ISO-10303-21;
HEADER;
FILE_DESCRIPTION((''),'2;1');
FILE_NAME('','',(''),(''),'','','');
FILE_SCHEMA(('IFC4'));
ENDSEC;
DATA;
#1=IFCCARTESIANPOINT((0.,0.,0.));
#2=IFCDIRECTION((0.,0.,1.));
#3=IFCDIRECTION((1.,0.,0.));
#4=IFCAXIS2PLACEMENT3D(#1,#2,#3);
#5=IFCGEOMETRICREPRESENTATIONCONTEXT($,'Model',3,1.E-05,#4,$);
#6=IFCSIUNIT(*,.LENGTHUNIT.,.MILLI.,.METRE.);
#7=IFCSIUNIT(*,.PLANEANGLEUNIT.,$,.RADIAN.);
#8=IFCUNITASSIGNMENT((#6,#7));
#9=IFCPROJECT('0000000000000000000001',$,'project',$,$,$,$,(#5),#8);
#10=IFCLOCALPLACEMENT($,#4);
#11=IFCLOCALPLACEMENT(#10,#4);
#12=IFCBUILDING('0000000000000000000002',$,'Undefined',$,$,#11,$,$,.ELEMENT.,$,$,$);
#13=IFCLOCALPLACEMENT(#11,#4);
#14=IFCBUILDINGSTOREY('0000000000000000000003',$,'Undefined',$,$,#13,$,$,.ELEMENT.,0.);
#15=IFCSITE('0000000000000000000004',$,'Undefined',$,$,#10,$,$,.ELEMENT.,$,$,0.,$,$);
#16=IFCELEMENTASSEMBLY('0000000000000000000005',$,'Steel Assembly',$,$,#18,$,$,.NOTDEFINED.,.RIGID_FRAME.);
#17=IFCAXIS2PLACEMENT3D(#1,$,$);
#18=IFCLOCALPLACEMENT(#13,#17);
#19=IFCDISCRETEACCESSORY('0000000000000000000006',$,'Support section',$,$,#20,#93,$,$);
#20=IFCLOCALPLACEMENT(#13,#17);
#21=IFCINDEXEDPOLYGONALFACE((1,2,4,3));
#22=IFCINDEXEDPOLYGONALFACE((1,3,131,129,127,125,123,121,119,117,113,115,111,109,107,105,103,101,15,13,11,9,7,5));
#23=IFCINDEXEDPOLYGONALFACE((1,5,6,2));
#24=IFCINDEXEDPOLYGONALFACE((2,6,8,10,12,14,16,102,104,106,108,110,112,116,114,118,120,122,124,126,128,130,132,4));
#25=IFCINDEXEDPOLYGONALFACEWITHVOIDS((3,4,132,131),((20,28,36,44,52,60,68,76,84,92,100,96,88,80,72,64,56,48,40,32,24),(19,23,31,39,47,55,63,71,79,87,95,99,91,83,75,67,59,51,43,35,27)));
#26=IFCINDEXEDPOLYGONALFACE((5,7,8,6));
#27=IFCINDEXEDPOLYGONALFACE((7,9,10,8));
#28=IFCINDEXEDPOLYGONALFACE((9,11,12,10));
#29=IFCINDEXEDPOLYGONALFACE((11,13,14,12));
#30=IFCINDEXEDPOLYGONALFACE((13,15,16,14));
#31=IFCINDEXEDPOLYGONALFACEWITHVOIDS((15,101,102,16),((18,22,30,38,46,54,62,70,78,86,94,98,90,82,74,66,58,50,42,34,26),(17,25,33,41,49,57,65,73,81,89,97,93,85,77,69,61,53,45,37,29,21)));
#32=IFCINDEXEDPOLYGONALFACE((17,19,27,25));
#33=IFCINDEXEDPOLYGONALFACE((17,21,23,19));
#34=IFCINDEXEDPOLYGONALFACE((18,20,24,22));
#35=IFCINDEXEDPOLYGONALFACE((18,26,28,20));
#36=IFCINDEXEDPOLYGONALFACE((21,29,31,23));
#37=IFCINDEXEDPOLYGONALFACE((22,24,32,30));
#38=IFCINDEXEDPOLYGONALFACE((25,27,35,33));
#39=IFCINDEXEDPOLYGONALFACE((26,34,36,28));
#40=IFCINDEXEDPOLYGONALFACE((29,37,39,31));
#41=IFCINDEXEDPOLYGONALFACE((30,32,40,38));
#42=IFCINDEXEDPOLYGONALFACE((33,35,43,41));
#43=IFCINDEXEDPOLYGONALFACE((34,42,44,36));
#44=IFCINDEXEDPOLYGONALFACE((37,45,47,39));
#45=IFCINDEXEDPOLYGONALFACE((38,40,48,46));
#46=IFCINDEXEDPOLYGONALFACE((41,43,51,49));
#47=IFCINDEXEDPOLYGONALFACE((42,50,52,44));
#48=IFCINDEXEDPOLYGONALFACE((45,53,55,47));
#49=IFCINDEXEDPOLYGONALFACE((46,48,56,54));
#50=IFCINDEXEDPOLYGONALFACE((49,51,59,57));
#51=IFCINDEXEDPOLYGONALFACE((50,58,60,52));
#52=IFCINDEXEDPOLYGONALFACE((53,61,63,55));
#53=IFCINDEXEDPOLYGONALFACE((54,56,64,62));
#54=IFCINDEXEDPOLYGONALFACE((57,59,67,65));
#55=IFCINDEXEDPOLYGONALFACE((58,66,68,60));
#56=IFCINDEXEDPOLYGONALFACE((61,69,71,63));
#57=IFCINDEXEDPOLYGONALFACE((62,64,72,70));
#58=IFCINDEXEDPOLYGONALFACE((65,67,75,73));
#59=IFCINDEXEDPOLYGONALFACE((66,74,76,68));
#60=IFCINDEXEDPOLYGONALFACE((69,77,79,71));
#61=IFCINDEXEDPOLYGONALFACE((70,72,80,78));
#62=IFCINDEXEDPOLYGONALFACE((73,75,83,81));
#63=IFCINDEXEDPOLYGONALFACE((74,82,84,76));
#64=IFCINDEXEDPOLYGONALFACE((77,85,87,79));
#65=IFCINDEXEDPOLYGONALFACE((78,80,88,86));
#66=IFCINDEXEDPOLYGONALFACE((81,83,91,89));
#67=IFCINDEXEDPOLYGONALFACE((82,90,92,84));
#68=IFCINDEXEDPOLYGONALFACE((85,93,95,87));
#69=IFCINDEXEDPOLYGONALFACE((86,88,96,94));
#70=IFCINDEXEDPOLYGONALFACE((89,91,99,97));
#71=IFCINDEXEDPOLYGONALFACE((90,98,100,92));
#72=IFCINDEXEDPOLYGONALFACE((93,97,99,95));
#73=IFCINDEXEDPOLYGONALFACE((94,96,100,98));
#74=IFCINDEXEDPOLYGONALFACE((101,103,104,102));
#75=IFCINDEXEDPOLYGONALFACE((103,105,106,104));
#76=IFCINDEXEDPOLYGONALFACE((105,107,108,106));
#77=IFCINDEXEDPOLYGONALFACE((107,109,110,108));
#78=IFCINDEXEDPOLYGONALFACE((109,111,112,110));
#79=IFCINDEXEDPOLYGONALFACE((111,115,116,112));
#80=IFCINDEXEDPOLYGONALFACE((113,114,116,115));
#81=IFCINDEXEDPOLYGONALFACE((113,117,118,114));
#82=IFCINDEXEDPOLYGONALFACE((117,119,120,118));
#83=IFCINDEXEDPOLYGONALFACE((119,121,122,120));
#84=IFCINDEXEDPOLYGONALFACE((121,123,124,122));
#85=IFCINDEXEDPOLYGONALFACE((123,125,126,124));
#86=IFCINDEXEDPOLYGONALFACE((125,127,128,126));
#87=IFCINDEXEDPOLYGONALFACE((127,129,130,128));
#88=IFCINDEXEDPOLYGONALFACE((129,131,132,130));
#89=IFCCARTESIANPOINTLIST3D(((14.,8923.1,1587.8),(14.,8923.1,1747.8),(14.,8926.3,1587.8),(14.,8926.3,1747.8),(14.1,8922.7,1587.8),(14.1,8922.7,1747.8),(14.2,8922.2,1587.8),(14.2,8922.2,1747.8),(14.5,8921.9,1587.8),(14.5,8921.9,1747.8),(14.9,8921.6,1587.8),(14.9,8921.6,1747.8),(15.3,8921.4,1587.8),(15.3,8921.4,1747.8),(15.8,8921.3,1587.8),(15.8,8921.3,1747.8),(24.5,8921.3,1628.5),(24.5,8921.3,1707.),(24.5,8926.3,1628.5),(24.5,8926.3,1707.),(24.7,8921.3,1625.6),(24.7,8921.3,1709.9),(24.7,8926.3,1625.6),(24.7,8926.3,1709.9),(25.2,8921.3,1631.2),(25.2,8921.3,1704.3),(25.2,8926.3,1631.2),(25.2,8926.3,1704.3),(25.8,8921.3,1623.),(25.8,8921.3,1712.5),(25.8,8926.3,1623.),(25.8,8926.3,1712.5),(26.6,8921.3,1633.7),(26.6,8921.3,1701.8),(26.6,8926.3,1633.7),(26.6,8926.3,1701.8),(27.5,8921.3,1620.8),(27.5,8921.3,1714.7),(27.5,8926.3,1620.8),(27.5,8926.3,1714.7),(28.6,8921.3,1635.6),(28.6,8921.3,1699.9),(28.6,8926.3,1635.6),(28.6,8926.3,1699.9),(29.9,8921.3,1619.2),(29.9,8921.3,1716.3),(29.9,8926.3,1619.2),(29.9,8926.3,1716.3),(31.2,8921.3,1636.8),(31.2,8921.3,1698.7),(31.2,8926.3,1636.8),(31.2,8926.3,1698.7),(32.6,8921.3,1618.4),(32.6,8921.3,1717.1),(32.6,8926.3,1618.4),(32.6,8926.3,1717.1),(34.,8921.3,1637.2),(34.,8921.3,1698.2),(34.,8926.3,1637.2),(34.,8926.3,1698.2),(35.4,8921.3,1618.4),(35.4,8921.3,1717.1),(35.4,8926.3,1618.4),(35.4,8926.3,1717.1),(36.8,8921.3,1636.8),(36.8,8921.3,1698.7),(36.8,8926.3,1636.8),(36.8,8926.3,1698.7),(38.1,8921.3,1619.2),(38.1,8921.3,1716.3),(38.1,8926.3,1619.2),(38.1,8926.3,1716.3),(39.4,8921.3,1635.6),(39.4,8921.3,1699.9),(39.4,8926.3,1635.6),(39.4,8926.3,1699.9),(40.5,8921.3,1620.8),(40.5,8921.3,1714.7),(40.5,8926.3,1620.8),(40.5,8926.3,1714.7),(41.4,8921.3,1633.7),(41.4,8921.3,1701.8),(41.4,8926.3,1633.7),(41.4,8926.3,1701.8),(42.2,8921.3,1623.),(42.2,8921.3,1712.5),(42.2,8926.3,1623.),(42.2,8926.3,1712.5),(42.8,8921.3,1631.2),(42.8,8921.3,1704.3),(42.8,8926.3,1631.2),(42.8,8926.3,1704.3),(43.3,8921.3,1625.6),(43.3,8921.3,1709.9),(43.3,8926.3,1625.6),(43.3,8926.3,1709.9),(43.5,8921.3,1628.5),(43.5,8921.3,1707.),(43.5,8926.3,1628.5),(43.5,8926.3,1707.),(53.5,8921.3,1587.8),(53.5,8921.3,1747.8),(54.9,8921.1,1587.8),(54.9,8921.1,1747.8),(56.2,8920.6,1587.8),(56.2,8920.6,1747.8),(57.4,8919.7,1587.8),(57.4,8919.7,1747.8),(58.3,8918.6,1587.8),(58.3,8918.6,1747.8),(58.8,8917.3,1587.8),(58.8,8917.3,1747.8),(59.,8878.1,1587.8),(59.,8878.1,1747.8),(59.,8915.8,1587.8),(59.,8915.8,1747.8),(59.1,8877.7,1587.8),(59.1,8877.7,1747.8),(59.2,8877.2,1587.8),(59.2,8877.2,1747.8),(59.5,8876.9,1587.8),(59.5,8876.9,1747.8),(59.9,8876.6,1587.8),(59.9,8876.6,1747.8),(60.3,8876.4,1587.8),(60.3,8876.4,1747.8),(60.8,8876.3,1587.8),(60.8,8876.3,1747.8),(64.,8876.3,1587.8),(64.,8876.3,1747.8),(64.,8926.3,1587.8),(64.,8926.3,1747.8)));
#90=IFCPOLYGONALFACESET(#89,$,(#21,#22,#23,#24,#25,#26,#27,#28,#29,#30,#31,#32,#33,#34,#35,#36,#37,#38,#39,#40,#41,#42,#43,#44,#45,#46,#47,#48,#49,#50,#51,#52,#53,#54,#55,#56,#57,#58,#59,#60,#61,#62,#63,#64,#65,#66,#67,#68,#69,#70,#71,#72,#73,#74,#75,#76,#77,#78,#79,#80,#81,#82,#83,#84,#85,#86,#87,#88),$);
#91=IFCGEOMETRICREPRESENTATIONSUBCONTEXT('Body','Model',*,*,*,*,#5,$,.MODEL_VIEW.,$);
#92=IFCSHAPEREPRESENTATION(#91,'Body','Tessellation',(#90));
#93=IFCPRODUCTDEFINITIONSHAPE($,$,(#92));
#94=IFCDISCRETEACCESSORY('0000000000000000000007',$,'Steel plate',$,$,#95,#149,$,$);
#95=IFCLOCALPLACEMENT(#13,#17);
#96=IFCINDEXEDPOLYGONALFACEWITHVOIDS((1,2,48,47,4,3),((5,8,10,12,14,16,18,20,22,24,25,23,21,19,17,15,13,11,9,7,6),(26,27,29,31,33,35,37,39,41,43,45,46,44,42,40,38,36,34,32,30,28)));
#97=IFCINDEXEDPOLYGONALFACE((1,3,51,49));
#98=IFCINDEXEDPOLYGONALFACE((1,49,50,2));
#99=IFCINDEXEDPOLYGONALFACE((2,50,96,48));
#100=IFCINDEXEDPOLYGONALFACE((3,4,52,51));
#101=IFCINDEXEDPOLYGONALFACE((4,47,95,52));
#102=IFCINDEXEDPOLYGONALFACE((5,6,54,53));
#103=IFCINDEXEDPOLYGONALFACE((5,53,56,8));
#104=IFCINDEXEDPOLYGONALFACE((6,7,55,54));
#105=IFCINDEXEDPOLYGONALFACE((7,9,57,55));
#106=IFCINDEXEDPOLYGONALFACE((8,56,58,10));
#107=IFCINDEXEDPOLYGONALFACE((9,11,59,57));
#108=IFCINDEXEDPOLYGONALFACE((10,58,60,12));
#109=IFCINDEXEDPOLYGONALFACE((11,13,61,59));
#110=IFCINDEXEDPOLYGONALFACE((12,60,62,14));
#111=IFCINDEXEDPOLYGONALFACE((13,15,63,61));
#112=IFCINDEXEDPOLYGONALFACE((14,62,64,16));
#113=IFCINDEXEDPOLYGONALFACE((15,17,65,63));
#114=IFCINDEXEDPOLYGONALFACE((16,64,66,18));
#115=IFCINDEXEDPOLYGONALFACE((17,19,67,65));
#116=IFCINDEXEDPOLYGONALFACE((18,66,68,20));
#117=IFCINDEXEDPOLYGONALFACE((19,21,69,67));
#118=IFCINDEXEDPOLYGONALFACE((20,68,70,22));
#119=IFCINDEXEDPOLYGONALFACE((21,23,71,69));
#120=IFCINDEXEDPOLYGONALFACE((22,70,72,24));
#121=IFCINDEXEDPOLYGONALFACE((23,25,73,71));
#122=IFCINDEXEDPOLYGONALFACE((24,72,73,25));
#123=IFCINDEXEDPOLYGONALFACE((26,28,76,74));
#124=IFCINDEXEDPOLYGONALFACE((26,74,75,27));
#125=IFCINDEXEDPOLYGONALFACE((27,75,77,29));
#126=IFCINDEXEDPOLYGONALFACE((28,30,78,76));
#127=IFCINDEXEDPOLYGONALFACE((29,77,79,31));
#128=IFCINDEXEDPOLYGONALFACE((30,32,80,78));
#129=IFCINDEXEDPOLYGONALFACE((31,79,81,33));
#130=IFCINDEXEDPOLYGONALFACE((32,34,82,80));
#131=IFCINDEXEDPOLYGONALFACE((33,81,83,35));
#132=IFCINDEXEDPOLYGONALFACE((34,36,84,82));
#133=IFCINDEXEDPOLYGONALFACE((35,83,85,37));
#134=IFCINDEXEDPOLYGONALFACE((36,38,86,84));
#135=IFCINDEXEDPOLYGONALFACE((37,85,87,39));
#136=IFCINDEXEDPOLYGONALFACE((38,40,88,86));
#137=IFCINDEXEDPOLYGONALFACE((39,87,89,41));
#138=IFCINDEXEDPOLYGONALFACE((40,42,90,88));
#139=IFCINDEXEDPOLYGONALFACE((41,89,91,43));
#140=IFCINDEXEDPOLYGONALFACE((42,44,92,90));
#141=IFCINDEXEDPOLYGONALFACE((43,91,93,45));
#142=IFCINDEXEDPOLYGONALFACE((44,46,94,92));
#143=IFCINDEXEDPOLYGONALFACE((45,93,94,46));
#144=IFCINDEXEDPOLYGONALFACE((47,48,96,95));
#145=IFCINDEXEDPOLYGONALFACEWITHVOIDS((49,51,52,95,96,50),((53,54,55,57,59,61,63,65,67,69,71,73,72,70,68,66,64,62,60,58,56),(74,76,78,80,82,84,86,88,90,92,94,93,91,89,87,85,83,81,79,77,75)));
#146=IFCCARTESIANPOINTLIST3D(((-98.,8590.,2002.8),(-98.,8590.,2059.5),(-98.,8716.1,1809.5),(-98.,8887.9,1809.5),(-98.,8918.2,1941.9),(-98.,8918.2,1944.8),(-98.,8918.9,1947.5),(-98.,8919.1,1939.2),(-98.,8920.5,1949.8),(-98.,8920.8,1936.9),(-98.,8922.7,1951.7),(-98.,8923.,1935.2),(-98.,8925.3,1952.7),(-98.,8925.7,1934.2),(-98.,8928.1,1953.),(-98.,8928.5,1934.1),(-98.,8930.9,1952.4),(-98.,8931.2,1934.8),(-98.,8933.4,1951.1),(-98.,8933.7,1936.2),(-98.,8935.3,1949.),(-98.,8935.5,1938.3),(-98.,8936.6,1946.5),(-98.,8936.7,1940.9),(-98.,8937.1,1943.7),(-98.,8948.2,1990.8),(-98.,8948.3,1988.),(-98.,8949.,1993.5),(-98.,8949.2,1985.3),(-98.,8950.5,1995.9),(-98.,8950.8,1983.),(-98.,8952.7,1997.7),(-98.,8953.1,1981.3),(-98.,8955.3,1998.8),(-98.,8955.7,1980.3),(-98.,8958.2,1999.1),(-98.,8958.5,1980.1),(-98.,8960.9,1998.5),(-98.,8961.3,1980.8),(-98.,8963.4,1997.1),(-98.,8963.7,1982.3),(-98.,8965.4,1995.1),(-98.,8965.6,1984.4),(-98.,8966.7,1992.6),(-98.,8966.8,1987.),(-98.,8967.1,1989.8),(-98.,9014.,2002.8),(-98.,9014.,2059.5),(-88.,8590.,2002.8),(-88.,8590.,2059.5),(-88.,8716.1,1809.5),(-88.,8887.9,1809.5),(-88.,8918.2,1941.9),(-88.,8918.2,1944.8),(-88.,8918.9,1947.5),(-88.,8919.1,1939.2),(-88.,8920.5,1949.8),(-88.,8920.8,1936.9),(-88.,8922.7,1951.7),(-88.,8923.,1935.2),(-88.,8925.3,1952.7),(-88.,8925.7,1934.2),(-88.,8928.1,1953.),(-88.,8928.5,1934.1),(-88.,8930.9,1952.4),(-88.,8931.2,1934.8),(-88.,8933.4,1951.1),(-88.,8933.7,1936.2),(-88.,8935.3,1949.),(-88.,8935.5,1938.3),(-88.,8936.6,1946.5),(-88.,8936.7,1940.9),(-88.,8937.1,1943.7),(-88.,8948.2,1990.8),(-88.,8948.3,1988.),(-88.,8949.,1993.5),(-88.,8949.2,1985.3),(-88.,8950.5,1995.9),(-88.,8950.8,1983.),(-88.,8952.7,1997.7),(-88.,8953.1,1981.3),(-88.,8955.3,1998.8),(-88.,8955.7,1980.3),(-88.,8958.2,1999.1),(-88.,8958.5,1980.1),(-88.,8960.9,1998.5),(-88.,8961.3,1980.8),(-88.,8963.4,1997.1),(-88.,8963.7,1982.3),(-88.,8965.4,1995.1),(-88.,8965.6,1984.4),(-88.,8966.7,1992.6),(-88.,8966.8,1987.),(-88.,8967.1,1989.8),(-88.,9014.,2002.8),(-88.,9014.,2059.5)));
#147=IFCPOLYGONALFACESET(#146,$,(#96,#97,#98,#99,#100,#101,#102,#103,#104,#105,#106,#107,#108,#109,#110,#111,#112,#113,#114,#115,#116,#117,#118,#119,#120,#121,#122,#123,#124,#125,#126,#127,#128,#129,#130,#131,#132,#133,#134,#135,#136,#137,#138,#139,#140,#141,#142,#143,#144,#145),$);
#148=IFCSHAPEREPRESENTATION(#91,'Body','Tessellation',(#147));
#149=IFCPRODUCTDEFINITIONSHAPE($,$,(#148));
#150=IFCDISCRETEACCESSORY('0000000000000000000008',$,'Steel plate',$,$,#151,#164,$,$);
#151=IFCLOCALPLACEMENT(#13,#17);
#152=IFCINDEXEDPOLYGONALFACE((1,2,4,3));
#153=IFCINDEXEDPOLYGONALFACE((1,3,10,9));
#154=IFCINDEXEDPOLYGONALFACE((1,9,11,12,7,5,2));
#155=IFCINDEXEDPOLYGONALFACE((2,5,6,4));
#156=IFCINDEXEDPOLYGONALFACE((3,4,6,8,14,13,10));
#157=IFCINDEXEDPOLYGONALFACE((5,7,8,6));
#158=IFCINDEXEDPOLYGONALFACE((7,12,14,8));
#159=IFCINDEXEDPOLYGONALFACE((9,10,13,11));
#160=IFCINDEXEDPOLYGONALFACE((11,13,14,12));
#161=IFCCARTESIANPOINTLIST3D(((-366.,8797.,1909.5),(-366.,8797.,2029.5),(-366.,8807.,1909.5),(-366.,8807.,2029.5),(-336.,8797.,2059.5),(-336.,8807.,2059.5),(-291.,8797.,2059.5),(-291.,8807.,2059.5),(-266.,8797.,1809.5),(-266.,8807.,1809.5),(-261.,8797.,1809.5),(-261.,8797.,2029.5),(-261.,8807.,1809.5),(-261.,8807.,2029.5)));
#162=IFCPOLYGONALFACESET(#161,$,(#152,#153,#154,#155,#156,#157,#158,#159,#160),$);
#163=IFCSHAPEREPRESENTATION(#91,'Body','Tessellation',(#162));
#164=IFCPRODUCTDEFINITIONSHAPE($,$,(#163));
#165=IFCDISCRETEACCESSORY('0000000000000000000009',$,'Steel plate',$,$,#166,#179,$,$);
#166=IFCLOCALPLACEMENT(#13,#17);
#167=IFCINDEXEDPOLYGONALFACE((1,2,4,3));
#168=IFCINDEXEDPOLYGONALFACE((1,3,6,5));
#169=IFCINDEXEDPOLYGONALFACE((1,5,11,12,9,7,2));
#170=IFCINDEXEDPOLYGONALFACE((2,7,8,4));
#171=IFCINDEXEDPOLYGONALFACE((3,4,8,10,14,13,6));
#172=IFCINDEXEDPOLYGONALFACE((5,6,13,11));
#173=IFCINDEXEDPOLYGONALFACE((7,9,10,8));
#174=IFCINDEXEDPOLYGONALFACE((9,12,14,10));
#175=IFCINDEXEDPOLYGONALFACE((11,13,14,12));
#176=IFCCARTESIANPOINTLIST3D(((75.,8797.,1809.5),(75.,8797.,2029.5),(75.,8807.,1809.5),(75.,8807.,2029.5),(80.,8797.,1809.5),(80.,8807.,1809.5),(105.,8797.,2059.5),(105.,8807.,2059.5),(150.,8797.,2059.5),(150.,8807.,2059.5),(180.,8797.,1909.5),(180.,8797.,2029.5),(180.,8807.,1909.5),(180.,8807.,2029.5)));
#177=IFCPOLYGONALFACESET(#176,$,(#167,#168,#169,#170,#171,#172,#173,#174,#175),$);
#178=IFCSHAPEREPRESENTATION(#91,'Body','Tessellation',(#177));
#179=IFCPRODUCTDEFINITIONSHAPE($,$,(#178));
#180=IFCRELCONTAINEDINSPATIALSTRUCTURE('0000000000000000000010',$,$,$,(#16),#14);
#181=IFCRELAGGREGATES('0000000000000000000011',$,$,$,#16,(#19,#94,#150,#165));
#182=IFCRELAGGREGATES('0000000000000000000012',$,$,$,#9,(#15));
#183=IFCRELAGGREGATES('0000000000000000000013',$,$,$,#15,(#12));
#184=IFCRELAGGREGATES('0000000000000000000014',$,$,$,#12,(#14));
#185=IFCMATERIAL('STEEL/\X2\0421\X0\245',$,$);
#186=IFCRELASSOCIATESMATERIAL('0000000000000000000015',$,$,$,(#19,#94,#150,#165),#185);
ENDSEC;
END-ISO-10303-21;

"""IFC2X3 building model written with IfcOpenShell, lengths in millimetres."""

from ifc_helpers import new_model, si_unit, frame, origin_with_axes, origin_2d_with_axis, place, context, subcontext, project, spatial, polyline, circle, l_section, outline, extrude, source, transform, mapped, material, element, aggregate, save


model = new_model("IFC2X3")

# Units and contexts
model_context = context("Model", 3, precision=1e-05, world=origin_with_axes())
body_context = subcontext(model_context, "Body", "Model", "MODEL_VIEW")
ifc_project = project(units=[si_unit("LENGTHUNIT", "METRE", prefix="MILLI"), si_unit("PLANEANGLEUNIT", "RADIAN")], contexts=[model_context])

# Site, building, storey
site_placement = place(None, origin_with_axes())
site = spatial("IfcSite", under=ifc_project, at=site_placement, Name="Undefined", CompositionType="ELEMENT", RefElevation=0.0)
building_placement = place(site_placement, origin_with_axes())
building = spatial("IfcBuilding", under=site, at=building_placement, Name="Undefined", CompositionType="ELEMENT")
storey_placement = place(building_placement, origin_with_axes())
storey = spatial("IfcBuildingStorey", under=building, at=storey_placement, Name="Undefined", CompositionType="ELEMENT", Elevation=0.0)

# Element assembly
assembly_1_placement = place(storey_placement, origin_with_axes())
assembly_1 = element("IfcElementAssembly", 1, at=assembly_1_placement, inside=storey, Name="Steel Assembly", AssemblyPlace="NOTDEFINED", PredefinedType="RIGID_FRAME")
ifc_material_1 = material(Name="STEEL/С245")

# Discrete accessory, openings
discrete_accessory_1_placement = place(assembly_1_placement, frame((39.0, 8901.3, 1747.8), z_axis=(0.0, -1.0, 0.0), x_axis=(0.0, 0.0, -1.0)))
discrete_accessory_1 = element("IfcDiscreteAccessory", 2, at=discrete_accessory_1_placement, material=ifc_material_1, Name="Support section", context=body_context, shape_type="SweptSolid", body=[
    extrude(l_section(Depth=50.0, Width=50.0, Thickness=5.0, FilletRadius=5.5, EdgeRadius=1.8, at=origin_2d_with_axis()), frame((160.0, 0.0, 0.0), z_axis=(-1.0, 0.0, 0.0), x_axis=(0.0, -1.0, 0.0)), (0.0, 0.0, 1.0), 160.0),
])
shared_shape_1 = source(origin_with_axes(), body_context, "Body", "SweptSolid", [
    extrude(circle(Radius=9.5, at=origin_2d_with_axis()), frame((0.0, -0.1, 0.0), z_axis=(0.0, 1.0, 0.0), x_axis=(1.0, 0.0, 0.0)), (0.0, 0.0, 1.0), 5.2),
])
opening_1_placement = place(assembly_1_placement, frame((34.0, 8926.3, 1627.8), z_axis=(1.0, 0.0, 0.0), x_axis=(0.0, 0.0, 1.0)))
element("IfcOpeningElement", 3, at=opening_1_placement, cuts=discrete_accessory_1, ObjectType="Opening", context=body_context, shape_type="MappedRepresentation", body=[
    mapped(shared_shape_1, transform((0.0, 0.0, 0.0))),
])
opening_2_placement = place(assembly_1_placement, frame((34.0, 8926.3, 1707.8), z_axis=(-1.0, 0.0, 0.0), x_axis=(0.0, 0.0, -1.0)))
element("IfcOpeningElement", 4, at=opening_2_placement, cuts=discrete_accessory_1, ObjectType="Opening", context=body_context, shape_type="MappedRepresentation", body=[
    mapped(shared_shape_1, transform((0.0, 0.0, 0.0))),
])

# Discrete accessory, opening
discrete_accessory_2_placement = place(assembly_1_placement, frame((-93.0, 8590.0, 2059.5), z_axis=(-1.0, 0.0, 0.0), x_axis=(0.0, 1.0, 0.0)))
discrete_accessory_2 = element("IfcDiscreteAccessory", 5, at=discrete_accessory_2_placement, material=ifc_material_1, Name="Steel plate", context=body_context, shape_type="SweptSolid", body=[
    extrude(outline(polyline([(0.0, 0.0), (424.0, 0.0), (424.0, 56.7), (297.9, 250.0), (126.1, 250.0), (0.0, 56.7), (0.0, 0.0)])), frame((0.0, 0.0, -5.0), z_axis=(0.0, 0.0, 1.0), x_axis=(1.0, 0.0, 0.0)), (0.0, 0.0, 1.0), 10.0),
])
shared_shape_2 = source(origin_with_axes(), body_context, "Body", "SweptSolid", [
    extrude(circle(Radius=9.5, at=origin_2d_with_axis()), frame((0.0, 3.9, 0.0), z_axis=(0.0, 1.0, 0.0), x_axis=(1.0, 0.0, 0.0)), (0.0, 0.0, 1.0), 14.1),
])
opening_3_placement = place(assembly_1_placement, frame((-84.0, 8942.6, 1966.6), z_axis=(0.0, 0.546313, 0.837581), x_axis=(0.0, 0.837581, -0.546313)))
element("IfcOpeningElement", 6, at=opening_3_placement, cuts=discrete_accessory_2, ObjectType="Opening", context=body_context, shape_type="MappedRepresentation", body=[
    mapped(shared_shape_2, transform((0.0, 0.0, -27.5))),
    mapped(shared_shape_2, transform((0.0, 0.0, 27.5))),
])

# Discrete accessories
discrete_accessory_3_placement = place(assembly_1_placement, frame((-261.0, 8802.0, 2059.5), z_axis=(0.0, -1.0, 0.0), x_axis=(-1.0, 0.0, 0.0)))
discrete_accessory_3 = element("IfcDiscreteAccessory", 7, at=discrete_accessory_3_placement, material=ifc_material_1, Name="Steel plate", context=body_context, shape_type="SweptSolid", body=[
    extrude(outline(polyline([(0.0, 30.0), (30.0, 0.0), (75.0, 0.0), (105.0, 30.0), (105.0, 150.0), (5.0, 250.0), (0.0, 250.0), (0.0, 30.0)])), frame((0.0, 0.0, -5.0), z_axis=(0.0, 0.0, 1.0), x_axis=(1.0, 0.0, 0.0)), (0.0, 0.0, 1.0), 10.0),
])
discrete_accessory_4_placement = place(assembly_1_placement, frame((75.0, 8802.0, 2059.5), z_axis=(0.0, 1.0, 0.0), x_axis=(1.0, 0.0, 0.0)))
discrete_accessory_4 = element("IfcDiscreteAccessory", 8, at=discrete_accessory_4_placement, material=ifc_material_1, Name="Steel plate", context=body_context, shape_type="SweptSolid", body=[
    extrude(outline(polyline([(0.0, 30.0), (30.0, 0.0), (75.0, 0.0), (105.0, 30.0), (105.0, 150.0), (5.0, 250.0), (0.0, 250.0), (0.0, 30.0)])), frame((0.0, 0.0, -5.0), z_axis=(0.0, 0.0, 1.0), x_axis=(1.0, 0.0, 0.0)), (0.0, 0.0, 1.0), 10.0),
])
aggregate(assembly_1, [discrete_accessory_1, discrete_accessory_2, discrete_accessory_3, discrete_accessory_4])

save(model, "model.ifc")
